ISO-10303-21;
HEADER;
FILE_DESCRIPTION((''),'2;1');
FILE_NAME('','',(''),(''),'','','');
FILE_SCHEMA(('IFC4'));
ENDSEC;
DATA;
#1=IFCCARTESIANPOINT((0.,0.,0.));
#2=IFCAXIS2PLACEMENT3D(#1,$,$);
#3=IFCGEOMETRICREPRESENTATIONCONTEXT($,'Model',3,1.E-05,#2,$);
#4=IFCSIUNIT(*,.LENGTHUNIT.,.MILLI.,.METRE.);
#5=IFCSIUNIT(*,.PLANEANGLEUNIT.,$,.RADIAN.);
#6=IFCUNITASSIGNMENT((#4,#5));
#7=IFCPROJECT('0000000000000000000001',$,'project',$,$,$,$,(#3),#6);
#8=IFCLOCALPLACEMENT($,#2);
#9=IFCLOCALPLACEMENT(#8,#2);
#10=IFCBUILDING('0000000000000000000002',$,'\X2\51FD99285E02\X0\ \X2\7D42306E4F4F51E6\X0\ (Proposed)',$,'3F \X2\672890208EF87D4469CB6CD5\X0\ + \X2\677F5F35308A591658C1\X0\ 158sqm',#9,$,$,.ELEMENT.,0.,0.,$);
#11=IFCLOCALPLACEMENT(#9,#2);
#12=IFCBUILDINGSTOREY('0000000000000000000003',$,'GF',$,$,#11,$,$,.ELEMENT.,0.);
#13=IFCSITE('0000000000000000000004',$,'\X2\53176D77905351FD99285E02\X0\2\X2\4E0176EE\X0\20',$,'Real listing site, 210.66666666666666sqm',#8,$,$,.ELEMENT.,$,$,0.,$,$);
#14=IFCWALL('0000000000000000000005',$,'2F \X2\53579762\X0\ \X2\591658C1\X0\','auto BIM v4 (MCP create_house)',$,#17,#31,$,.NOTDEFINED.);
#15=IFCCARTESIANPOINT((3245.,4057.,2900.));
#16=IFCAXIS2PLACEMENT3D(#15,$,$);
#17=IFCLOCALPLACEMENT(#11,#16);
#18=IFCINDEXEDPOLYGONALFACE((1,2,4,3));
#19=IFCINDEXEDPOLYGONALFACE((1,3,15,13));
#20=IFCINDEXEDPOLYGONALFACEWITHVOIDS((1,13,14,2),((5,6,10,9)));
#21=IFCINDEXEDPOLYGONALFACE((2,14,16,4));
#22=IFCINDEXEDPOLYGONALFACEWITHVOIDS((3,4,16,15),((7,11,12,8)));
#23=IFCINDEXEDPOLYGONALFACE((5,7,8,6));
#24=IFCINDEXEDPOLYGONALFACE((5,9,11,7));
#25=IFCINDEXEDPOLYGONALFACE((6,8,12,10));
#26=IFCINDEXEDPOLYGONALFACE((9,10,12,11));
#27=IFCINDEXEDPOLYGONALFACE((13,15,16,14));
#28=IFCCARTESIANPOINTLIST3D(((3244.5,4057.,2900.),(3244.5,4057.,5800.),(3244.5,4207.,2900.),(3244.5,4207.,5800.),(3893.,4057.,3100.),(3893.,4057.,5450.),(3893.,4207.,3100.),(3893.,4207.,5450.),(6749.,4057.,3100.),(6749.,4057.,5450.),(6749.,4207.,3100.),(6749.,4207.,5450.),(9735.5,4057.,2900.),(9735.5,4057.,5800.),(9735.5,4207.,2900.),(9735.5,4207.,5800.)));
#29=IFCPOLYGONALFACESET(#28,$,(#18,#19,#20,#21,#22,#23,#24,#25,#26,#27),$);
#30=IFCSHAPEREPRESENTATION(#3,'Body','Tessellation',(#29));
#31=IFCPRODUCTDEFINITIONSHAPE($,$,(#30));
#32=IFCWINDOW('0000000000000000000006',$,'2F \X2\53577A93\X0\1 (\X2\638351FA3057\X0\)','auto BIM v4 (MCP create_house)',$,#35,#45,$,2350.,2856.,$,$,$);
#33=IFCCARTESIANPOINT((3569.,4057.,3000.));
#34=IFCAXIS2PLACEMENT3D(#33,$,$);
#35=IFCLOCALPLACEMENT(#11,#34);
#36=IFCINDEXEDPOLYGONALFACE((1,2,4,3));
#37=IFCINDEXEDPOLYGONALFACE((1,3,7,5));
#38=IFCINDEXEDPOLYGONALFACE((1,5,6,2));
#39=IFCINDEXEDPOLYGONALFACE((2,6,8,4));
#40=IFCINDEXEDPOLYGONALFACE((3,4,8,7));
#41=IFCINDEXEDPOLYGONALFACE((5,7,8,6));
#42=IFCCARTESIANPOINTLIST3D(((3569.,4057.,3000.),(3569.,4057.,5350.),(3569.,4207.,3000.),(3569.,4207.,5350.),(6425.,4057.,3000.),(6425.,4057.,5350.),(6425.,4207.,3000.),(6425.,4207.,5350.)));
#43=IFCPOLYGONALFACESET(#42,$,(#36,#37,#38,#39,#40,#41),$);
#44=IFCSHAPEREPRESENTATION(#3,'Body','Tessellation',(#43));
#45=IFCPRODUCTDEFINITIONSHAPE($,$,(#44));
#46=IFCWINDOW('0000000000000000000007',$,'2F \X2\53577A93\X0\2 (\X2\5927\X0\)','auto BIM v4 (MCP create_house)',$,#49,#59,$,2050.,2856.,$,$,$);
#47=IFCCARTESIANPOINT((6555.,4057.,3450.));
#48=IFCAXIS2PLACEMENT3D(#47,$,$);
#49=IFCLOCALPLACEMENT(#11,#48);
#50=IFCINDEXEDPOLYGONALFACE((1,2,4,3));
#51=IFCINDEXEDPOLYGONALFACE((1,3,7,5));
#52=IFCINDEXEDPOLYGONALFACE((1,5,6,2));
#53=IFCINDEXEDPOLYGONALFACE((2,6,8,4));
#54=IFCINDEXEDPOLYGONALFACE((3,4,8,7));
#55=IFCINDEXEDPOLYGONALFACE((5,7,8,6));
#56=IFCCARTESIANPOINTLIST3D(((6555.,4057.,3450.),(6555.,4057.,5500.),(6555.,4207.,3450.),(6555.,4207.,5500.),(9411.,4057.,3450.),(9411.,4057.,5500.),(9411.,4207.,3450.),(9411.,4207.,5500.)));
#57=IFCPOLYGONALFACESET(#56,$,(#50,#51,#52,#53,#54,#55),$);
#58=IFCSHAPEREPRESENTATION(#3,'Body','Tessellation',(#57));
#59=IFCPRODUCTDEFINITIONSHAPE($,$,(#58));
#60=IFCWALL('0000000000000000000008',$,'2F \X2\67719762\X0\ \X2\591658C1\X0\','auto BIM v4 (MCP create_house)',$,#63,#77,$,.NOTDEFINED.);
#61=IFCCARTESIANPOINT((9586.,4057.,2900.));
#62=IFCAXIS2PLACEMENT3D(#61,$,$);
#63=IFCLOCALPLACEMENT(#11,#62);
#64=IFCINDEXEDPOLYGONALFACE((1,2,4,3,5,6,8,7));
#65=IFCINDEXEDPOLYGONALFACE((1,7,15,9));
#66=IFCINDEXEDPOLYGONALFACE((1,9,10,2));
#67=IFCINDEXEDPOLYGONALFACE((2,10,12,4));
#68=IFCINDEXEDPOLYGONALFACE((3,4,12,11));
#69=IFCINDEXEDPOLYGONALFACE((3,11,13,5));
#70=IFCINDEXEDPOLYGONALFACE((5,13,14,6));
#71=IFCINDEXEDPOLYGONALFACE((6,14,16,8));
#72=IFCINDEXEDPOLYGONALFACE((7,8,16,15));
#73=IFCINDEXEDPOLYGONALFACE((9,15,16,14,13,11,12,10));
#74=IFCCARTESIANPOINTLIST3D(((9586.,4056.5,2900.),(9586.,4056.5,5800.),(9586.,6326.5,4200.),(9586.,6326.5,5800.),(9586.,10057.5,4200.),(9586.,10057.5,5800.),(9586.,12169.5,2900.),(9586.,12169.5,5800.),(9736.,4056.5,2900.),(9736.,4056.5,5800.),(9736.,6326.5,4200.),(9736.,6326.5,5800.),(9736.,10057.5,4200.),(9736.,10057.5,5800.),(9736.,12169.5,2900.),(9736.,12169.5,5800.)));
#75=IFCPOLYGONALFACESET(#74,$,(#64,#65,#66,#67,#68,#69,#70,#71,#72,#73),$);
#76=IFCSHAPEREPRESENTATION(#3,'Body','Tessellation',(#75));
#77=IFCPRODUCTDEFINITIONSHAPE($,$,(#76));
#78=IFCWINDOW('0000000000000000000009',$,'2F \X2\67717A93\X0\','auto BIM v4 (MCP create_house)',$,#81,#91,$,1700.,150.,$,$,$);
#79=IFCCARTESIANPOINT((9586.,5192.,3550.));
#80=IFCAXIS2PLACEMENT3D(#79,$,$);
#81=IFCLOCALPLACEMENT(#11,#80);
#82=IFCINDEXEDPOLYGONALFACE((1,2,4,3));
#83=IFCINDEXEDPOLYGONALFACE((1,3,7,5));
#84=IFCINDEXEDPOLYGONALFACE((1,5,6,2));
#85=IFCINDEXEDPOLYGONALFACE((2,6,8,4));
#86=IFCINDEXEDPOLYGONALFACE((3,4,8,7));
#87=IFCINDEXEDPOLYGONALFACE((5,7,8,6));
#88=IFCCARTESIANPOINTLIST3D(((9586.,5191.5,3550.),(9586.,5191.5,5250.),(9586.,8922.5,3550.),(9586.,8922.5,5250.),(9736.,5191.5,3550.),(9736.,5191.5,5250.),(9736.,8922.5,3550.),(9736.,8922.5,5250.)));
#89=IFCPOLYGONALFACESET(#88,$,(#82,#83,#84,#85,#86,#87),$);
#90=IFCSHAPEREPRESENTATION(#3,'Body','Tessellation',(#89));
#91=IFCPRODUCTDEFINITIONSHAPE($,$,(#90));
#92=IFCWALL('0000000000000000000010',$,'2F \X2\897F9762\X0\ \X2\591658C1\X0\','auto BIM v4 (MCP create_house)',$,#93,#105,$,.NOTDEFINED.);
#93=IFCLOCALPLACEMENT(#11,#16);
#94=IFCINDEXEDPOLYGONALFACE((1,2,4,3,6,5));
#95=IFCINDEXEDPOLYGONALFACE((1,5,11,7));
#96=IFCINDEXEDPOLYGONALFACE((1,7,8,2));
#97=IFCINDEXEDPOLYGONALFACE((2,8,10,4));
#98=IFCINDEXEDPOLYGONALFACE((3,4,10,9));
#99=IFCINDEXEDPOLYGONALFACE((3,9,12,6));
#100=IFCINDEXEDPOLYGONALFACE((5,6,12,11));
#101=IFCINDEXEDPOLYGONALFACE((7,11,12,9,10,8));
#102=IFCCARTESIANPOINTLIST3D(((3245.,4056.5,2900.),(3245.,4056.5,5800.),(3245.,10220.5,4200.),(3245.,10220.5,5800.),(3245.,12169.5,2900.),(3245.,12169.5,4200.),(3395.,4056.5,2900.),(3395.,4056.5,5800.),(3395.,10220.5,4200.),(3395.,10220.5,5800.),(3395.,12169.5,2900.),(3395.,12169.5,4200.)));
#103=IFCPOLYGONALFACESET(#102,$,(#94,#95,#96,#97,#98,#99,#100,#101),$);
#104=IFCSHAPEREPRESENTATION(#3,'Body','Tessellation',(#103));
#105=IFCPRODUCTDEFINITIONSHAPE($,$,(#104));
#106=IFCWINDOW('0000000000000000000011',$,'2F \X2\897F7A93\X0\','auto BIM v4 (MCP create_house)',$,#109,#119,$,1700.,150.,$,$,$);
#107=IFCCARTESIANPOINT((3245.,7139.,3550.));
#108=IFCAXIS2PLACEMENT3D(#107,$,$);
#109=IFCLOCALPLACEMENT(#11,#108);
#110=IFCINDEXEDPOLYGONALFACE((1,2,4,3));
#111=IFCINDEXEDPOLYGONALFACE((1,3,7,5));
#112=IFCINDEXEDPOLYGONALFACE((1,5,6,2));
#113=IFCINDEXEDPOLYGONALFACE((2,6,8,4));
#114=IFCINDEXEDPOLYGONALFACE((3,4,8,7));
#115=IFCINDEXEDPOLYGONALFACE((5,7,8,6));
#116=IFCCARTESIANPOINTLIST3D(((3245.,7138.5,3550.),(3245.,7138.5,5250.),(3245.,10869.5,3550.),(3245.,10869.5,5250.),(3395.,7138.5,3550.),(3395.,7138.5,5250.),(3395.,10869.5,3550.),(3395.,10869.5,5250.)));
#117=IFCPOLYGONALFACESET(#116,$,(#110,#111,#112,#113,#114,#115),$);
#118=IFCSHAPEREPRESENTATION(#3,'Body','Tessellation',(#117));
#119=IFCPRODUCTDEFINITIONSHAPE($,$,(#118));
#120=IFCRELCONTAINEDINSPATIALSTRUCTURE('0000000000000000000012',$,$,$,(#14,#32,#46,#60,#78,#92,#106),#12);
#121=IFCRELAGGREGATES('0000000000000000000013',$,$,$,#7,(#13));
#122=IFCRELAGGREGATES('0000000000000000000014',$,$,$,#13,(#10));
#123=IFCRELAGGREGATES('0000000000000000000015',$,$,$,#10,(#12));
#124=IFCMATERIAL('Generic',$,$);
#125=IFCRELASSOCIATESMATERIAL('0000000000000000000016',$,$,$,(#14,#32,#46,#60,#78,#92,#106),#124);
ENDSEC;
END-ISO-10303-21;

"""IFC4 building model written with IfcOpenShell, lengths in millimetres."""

from ifc_helpers import new_model, si_unit, frame, frame_2d, origin, place, context, project, spatial, rectangle, extrude, material, element, fill, save


model = new_model("IFC4")

# Units and contexts
model_context = context("Model", 3, precision=1e-05, world=origin())
ifc_project = project(units=[si_unit("LENGTHUNIT", "METRE", prefix="MILLI"), si_unit("PLANEANGLEUNIT", "RADIAN")], contexts=[model_context])

# Site, building, storey
site_placement = place(None, origin())
site = spatial("IfcSite", under=ifc_project, at=site_placement, Name="北海道函館市2丁目20", ObjectType="Real listing site, 210.66666666666666sqm", CompositionType="ELEMENT", RefElevation=0.0)
building_placement = place(site_placement, origin())
building = spatial("IfcBuilding", under=site, at=building_placement, Name="函館市 終の住処 (Proposed)", ObjectType="3F 木造軸組構法 + 板張り外壁 158sqm", CompositionType="ELEMENT", ElevationOfRefHeight=0.0, ElevationOfTerrain=0.0)
storey_placement = place(building_placement, origin())
storey = spatial("IfcBuildingStorey", under=building, at=storey_placement, Name="GF", CompositionType="ELEMENT", Elevation=0.0)

# Shared definitions
ifc_material = material(Name="Generic")

# Wall, openings, windows
wall_1_placement = place(storey_placement, frame((3245.0, 4057.0, 2900.0)))
wall_1 = element("IfcWall", 1, at=wall_1_placement, inside=storey, material=ifc_material, Name="2F 南面 外壁", Description="auto BIM v4 (MCP create_house)", PredefinedType="NOTDEFINED", context=model_context, shape_type="SweptSolid", body=[
    extrude(rectangle(XDim=6491.0, YDim=150.0, at=frame_2d((3245.0, 75.0))), frame((3245.0, 4057.0, 2900.0)), (0.0, 0.0, 1.0), 2900.0),
])
opening_1_placement = place(storey_placement, frame((3569.0, 4057.0, 3000.0)))
opening_1 = element("IfcOpeningElement", 2, at=opening_1_placement, cuts=wall_1, PredefinedType="NOTDEFINED", context=model_context, shape_type="SweptSolid", body=[
    extrude(rectangle(XDim=2856.0, YDim=150.0, at=frame_2d((1428.0, 75.0))), frame((3569.0, 4057.0, 3000.0)), (0.0, 0.0, 1.0), 2350.0),
])
opening_2_placement = place(storey_placement, frame((6555.0, 4057.0, 3450.0)))
opening_2 = element("IfcOpeningElement", 3, at=opening_2_placement, cuts=wall_1, PredefinedType="NOTDEFINED", context=model_context, shape_type="SweptSolid", body=[
    extrude(rectangle(XDim=2856.0, YDim=150.0, at=frame_2d((1428.0, 75.0))), frame((6555.0, 4057.0, 3450.0)), (0.0, 0.0, 1.0), 2050.0),
])
window_1_placement = place(storey_placement, frame((3569.0, 4057.0, 3000.0)))
window_1 = element("IfcWindow", 4, at=window_1_placement, inside=storey, material=ifc_material, Name="2F 南窓1 (掃出し)", Description="auto BIM v4 (MCP create_house)", OverallHeight=2350.0, OverallWidth=2856.0, context=model_context, shape_type="SweptSolid", body=[
    extrude(rectangle(XDim=2856.0, YDim=150.0, at=frame_2d((1428.0, 75.0))), frame((3569.0, 4057.0, 3000.0)), (0.0, 0.0, 1.0), 2350.0),
])
fill(opening_1, window_1)
window_2_placement = place(storey_placement, frame((6555.0, 4057.0, 3450.0)))
window_2 = element("IfcWindow", 5, at=window_2_placement, inside=storey, material=ifc_material, Name="2F 南窓2 (大)", Description="auto BIM v4 (MCP create_house)", OverallHeight=2050.0, OverallWidth=2856.0, context=model_context, shape_type="SweptSolid", body=[
    extrude(rectangle(XDim=2856.0, YDim=150.0, at=frame_2d((1428.0, 75.0))), frame((6555.0, 4057.0, 3450.0)), (0.0, 0.0, 1.0), 2050.0),
])
fill(opening_2, window_2)

# Walls, openings, windows
wall_2_placement = place(storey_placement, frame((9586.0, 4057.0, 2900.0)))
wall_2 = element("IfcWall", 6, at=wall_2_placement, inside=storey, material=ifc_material, Name="2F 東面 外壁", Description="auto BIM v4 (MCP create_house)", PredefinedType="NOTDEFINED", context=model_context, shape_type="SweptSolid", body=[
    extrude(rectangle(XDim=150.0, YDim=8113.0, at=frame_2d((75.0, 4056.0))), frame((9586.0, 4057.0, 2900.0)), (0.0, 0.0, 1.0), 2900.0),
])
opening_3_placement = place(storey_placement, frame((9586.0, 5192.0, 3550.0)))
opening_3 = element("IfcOpeningElement", 7, at=opening_3_placement, cuts=wall_2, PredefinedType="NOTDEFINED", context=model_context, shape_type="SweptSolid", body=[
    extrude(rectangle(XDim=150.0, YDim=3731.0, at=frame_2d((75.0, 1865.0))), frame((9586.0, 5192.0, 3550.0)), (0.0, 0.0, 1.0), 1700.0),
])
window_3_placement = place(storey_placement, frame((9586.0, 5192.0, 3550.0)))
window_3 = element("IfcWindow", 8, at=window_3_placement, inside=storey, material=ifc_material, Name="2F 東窓", Description="auto BIM v4 (MCP create_house)", OverallHeight=1700.0, OverallWidth=150.0, context=model_context, shape_type="SweptSolid", body=[
    extrude(rectangle(XDim=150.0, YDim=3731.0, at=frame_2d((75.0, 1865.0))), frame((9586.0, 5192.0, 3550.0)), (0.0, 0.0, 1.0), 1700.0),
])
fill(opening_3, window_3)
wall_3_placement = place(storey_placement, frame((3245.0, 4057.0, 2900.0)))
wall_3 = element("IfcWall", 9, at=wall_3_placement, inside=storey, material=ifc_material, Name="2F 西面 外壁", Description="auto BIM v4 (MCP create_house)", PredefinedType="NOTDEFINED", context=model_context, shape_type="SweptSolid", body=[
    extrude(rectangle(XDim=150.0, YDim=8113.0, at=frame_2d((75.0, 4056.0))), frame((3245.0, 4057.0, 2900.0)), (0.0, 0.0, 1.0), 2900.0),
])
opening_4_placement = place(storey_placement, frame((3245.0, 7139.0, 3550.0)))
opening_4 = element("IfcOpeningElement", 10, at=opening_4_placement, cuts=wall_3, PredefinedType="NOTDEFINED", context=model_context, shape_type="SweptSolid", body=[
    extrude(rectangle(XDim=150.0, YDim=3731.0, at=frame_2d((75.0, 1865.0))), frame((3245.0, 7139.0, 3550.0)), (0.0, 0.0, 1.0), 1700.0),
])
window_4_placement = place(storey_placement, frame((3245.0, 7139.0, 3550.0)))
window_4 = element("IfcWindow", 11, at=window_4_placement, inside=storey, material=ifc_material, Name="2F 西窓", Description="auto BIM v4 (MCP create_house)", OverallHeight=1700.0, OverallWidth=150.0, context=model_context, shape_type="SweptSolid", body=[
    extrude(rectangle(XDim=150.0, YDim=3731.0, at=frame_2d((75.0, 1865.0))), frame((3245.0, 7139.0, 3550.0)), (0.0, 0.0, 1.0), 1700.0),
])
fill(opening_4, window_4)

save(model, "model.ifc")
